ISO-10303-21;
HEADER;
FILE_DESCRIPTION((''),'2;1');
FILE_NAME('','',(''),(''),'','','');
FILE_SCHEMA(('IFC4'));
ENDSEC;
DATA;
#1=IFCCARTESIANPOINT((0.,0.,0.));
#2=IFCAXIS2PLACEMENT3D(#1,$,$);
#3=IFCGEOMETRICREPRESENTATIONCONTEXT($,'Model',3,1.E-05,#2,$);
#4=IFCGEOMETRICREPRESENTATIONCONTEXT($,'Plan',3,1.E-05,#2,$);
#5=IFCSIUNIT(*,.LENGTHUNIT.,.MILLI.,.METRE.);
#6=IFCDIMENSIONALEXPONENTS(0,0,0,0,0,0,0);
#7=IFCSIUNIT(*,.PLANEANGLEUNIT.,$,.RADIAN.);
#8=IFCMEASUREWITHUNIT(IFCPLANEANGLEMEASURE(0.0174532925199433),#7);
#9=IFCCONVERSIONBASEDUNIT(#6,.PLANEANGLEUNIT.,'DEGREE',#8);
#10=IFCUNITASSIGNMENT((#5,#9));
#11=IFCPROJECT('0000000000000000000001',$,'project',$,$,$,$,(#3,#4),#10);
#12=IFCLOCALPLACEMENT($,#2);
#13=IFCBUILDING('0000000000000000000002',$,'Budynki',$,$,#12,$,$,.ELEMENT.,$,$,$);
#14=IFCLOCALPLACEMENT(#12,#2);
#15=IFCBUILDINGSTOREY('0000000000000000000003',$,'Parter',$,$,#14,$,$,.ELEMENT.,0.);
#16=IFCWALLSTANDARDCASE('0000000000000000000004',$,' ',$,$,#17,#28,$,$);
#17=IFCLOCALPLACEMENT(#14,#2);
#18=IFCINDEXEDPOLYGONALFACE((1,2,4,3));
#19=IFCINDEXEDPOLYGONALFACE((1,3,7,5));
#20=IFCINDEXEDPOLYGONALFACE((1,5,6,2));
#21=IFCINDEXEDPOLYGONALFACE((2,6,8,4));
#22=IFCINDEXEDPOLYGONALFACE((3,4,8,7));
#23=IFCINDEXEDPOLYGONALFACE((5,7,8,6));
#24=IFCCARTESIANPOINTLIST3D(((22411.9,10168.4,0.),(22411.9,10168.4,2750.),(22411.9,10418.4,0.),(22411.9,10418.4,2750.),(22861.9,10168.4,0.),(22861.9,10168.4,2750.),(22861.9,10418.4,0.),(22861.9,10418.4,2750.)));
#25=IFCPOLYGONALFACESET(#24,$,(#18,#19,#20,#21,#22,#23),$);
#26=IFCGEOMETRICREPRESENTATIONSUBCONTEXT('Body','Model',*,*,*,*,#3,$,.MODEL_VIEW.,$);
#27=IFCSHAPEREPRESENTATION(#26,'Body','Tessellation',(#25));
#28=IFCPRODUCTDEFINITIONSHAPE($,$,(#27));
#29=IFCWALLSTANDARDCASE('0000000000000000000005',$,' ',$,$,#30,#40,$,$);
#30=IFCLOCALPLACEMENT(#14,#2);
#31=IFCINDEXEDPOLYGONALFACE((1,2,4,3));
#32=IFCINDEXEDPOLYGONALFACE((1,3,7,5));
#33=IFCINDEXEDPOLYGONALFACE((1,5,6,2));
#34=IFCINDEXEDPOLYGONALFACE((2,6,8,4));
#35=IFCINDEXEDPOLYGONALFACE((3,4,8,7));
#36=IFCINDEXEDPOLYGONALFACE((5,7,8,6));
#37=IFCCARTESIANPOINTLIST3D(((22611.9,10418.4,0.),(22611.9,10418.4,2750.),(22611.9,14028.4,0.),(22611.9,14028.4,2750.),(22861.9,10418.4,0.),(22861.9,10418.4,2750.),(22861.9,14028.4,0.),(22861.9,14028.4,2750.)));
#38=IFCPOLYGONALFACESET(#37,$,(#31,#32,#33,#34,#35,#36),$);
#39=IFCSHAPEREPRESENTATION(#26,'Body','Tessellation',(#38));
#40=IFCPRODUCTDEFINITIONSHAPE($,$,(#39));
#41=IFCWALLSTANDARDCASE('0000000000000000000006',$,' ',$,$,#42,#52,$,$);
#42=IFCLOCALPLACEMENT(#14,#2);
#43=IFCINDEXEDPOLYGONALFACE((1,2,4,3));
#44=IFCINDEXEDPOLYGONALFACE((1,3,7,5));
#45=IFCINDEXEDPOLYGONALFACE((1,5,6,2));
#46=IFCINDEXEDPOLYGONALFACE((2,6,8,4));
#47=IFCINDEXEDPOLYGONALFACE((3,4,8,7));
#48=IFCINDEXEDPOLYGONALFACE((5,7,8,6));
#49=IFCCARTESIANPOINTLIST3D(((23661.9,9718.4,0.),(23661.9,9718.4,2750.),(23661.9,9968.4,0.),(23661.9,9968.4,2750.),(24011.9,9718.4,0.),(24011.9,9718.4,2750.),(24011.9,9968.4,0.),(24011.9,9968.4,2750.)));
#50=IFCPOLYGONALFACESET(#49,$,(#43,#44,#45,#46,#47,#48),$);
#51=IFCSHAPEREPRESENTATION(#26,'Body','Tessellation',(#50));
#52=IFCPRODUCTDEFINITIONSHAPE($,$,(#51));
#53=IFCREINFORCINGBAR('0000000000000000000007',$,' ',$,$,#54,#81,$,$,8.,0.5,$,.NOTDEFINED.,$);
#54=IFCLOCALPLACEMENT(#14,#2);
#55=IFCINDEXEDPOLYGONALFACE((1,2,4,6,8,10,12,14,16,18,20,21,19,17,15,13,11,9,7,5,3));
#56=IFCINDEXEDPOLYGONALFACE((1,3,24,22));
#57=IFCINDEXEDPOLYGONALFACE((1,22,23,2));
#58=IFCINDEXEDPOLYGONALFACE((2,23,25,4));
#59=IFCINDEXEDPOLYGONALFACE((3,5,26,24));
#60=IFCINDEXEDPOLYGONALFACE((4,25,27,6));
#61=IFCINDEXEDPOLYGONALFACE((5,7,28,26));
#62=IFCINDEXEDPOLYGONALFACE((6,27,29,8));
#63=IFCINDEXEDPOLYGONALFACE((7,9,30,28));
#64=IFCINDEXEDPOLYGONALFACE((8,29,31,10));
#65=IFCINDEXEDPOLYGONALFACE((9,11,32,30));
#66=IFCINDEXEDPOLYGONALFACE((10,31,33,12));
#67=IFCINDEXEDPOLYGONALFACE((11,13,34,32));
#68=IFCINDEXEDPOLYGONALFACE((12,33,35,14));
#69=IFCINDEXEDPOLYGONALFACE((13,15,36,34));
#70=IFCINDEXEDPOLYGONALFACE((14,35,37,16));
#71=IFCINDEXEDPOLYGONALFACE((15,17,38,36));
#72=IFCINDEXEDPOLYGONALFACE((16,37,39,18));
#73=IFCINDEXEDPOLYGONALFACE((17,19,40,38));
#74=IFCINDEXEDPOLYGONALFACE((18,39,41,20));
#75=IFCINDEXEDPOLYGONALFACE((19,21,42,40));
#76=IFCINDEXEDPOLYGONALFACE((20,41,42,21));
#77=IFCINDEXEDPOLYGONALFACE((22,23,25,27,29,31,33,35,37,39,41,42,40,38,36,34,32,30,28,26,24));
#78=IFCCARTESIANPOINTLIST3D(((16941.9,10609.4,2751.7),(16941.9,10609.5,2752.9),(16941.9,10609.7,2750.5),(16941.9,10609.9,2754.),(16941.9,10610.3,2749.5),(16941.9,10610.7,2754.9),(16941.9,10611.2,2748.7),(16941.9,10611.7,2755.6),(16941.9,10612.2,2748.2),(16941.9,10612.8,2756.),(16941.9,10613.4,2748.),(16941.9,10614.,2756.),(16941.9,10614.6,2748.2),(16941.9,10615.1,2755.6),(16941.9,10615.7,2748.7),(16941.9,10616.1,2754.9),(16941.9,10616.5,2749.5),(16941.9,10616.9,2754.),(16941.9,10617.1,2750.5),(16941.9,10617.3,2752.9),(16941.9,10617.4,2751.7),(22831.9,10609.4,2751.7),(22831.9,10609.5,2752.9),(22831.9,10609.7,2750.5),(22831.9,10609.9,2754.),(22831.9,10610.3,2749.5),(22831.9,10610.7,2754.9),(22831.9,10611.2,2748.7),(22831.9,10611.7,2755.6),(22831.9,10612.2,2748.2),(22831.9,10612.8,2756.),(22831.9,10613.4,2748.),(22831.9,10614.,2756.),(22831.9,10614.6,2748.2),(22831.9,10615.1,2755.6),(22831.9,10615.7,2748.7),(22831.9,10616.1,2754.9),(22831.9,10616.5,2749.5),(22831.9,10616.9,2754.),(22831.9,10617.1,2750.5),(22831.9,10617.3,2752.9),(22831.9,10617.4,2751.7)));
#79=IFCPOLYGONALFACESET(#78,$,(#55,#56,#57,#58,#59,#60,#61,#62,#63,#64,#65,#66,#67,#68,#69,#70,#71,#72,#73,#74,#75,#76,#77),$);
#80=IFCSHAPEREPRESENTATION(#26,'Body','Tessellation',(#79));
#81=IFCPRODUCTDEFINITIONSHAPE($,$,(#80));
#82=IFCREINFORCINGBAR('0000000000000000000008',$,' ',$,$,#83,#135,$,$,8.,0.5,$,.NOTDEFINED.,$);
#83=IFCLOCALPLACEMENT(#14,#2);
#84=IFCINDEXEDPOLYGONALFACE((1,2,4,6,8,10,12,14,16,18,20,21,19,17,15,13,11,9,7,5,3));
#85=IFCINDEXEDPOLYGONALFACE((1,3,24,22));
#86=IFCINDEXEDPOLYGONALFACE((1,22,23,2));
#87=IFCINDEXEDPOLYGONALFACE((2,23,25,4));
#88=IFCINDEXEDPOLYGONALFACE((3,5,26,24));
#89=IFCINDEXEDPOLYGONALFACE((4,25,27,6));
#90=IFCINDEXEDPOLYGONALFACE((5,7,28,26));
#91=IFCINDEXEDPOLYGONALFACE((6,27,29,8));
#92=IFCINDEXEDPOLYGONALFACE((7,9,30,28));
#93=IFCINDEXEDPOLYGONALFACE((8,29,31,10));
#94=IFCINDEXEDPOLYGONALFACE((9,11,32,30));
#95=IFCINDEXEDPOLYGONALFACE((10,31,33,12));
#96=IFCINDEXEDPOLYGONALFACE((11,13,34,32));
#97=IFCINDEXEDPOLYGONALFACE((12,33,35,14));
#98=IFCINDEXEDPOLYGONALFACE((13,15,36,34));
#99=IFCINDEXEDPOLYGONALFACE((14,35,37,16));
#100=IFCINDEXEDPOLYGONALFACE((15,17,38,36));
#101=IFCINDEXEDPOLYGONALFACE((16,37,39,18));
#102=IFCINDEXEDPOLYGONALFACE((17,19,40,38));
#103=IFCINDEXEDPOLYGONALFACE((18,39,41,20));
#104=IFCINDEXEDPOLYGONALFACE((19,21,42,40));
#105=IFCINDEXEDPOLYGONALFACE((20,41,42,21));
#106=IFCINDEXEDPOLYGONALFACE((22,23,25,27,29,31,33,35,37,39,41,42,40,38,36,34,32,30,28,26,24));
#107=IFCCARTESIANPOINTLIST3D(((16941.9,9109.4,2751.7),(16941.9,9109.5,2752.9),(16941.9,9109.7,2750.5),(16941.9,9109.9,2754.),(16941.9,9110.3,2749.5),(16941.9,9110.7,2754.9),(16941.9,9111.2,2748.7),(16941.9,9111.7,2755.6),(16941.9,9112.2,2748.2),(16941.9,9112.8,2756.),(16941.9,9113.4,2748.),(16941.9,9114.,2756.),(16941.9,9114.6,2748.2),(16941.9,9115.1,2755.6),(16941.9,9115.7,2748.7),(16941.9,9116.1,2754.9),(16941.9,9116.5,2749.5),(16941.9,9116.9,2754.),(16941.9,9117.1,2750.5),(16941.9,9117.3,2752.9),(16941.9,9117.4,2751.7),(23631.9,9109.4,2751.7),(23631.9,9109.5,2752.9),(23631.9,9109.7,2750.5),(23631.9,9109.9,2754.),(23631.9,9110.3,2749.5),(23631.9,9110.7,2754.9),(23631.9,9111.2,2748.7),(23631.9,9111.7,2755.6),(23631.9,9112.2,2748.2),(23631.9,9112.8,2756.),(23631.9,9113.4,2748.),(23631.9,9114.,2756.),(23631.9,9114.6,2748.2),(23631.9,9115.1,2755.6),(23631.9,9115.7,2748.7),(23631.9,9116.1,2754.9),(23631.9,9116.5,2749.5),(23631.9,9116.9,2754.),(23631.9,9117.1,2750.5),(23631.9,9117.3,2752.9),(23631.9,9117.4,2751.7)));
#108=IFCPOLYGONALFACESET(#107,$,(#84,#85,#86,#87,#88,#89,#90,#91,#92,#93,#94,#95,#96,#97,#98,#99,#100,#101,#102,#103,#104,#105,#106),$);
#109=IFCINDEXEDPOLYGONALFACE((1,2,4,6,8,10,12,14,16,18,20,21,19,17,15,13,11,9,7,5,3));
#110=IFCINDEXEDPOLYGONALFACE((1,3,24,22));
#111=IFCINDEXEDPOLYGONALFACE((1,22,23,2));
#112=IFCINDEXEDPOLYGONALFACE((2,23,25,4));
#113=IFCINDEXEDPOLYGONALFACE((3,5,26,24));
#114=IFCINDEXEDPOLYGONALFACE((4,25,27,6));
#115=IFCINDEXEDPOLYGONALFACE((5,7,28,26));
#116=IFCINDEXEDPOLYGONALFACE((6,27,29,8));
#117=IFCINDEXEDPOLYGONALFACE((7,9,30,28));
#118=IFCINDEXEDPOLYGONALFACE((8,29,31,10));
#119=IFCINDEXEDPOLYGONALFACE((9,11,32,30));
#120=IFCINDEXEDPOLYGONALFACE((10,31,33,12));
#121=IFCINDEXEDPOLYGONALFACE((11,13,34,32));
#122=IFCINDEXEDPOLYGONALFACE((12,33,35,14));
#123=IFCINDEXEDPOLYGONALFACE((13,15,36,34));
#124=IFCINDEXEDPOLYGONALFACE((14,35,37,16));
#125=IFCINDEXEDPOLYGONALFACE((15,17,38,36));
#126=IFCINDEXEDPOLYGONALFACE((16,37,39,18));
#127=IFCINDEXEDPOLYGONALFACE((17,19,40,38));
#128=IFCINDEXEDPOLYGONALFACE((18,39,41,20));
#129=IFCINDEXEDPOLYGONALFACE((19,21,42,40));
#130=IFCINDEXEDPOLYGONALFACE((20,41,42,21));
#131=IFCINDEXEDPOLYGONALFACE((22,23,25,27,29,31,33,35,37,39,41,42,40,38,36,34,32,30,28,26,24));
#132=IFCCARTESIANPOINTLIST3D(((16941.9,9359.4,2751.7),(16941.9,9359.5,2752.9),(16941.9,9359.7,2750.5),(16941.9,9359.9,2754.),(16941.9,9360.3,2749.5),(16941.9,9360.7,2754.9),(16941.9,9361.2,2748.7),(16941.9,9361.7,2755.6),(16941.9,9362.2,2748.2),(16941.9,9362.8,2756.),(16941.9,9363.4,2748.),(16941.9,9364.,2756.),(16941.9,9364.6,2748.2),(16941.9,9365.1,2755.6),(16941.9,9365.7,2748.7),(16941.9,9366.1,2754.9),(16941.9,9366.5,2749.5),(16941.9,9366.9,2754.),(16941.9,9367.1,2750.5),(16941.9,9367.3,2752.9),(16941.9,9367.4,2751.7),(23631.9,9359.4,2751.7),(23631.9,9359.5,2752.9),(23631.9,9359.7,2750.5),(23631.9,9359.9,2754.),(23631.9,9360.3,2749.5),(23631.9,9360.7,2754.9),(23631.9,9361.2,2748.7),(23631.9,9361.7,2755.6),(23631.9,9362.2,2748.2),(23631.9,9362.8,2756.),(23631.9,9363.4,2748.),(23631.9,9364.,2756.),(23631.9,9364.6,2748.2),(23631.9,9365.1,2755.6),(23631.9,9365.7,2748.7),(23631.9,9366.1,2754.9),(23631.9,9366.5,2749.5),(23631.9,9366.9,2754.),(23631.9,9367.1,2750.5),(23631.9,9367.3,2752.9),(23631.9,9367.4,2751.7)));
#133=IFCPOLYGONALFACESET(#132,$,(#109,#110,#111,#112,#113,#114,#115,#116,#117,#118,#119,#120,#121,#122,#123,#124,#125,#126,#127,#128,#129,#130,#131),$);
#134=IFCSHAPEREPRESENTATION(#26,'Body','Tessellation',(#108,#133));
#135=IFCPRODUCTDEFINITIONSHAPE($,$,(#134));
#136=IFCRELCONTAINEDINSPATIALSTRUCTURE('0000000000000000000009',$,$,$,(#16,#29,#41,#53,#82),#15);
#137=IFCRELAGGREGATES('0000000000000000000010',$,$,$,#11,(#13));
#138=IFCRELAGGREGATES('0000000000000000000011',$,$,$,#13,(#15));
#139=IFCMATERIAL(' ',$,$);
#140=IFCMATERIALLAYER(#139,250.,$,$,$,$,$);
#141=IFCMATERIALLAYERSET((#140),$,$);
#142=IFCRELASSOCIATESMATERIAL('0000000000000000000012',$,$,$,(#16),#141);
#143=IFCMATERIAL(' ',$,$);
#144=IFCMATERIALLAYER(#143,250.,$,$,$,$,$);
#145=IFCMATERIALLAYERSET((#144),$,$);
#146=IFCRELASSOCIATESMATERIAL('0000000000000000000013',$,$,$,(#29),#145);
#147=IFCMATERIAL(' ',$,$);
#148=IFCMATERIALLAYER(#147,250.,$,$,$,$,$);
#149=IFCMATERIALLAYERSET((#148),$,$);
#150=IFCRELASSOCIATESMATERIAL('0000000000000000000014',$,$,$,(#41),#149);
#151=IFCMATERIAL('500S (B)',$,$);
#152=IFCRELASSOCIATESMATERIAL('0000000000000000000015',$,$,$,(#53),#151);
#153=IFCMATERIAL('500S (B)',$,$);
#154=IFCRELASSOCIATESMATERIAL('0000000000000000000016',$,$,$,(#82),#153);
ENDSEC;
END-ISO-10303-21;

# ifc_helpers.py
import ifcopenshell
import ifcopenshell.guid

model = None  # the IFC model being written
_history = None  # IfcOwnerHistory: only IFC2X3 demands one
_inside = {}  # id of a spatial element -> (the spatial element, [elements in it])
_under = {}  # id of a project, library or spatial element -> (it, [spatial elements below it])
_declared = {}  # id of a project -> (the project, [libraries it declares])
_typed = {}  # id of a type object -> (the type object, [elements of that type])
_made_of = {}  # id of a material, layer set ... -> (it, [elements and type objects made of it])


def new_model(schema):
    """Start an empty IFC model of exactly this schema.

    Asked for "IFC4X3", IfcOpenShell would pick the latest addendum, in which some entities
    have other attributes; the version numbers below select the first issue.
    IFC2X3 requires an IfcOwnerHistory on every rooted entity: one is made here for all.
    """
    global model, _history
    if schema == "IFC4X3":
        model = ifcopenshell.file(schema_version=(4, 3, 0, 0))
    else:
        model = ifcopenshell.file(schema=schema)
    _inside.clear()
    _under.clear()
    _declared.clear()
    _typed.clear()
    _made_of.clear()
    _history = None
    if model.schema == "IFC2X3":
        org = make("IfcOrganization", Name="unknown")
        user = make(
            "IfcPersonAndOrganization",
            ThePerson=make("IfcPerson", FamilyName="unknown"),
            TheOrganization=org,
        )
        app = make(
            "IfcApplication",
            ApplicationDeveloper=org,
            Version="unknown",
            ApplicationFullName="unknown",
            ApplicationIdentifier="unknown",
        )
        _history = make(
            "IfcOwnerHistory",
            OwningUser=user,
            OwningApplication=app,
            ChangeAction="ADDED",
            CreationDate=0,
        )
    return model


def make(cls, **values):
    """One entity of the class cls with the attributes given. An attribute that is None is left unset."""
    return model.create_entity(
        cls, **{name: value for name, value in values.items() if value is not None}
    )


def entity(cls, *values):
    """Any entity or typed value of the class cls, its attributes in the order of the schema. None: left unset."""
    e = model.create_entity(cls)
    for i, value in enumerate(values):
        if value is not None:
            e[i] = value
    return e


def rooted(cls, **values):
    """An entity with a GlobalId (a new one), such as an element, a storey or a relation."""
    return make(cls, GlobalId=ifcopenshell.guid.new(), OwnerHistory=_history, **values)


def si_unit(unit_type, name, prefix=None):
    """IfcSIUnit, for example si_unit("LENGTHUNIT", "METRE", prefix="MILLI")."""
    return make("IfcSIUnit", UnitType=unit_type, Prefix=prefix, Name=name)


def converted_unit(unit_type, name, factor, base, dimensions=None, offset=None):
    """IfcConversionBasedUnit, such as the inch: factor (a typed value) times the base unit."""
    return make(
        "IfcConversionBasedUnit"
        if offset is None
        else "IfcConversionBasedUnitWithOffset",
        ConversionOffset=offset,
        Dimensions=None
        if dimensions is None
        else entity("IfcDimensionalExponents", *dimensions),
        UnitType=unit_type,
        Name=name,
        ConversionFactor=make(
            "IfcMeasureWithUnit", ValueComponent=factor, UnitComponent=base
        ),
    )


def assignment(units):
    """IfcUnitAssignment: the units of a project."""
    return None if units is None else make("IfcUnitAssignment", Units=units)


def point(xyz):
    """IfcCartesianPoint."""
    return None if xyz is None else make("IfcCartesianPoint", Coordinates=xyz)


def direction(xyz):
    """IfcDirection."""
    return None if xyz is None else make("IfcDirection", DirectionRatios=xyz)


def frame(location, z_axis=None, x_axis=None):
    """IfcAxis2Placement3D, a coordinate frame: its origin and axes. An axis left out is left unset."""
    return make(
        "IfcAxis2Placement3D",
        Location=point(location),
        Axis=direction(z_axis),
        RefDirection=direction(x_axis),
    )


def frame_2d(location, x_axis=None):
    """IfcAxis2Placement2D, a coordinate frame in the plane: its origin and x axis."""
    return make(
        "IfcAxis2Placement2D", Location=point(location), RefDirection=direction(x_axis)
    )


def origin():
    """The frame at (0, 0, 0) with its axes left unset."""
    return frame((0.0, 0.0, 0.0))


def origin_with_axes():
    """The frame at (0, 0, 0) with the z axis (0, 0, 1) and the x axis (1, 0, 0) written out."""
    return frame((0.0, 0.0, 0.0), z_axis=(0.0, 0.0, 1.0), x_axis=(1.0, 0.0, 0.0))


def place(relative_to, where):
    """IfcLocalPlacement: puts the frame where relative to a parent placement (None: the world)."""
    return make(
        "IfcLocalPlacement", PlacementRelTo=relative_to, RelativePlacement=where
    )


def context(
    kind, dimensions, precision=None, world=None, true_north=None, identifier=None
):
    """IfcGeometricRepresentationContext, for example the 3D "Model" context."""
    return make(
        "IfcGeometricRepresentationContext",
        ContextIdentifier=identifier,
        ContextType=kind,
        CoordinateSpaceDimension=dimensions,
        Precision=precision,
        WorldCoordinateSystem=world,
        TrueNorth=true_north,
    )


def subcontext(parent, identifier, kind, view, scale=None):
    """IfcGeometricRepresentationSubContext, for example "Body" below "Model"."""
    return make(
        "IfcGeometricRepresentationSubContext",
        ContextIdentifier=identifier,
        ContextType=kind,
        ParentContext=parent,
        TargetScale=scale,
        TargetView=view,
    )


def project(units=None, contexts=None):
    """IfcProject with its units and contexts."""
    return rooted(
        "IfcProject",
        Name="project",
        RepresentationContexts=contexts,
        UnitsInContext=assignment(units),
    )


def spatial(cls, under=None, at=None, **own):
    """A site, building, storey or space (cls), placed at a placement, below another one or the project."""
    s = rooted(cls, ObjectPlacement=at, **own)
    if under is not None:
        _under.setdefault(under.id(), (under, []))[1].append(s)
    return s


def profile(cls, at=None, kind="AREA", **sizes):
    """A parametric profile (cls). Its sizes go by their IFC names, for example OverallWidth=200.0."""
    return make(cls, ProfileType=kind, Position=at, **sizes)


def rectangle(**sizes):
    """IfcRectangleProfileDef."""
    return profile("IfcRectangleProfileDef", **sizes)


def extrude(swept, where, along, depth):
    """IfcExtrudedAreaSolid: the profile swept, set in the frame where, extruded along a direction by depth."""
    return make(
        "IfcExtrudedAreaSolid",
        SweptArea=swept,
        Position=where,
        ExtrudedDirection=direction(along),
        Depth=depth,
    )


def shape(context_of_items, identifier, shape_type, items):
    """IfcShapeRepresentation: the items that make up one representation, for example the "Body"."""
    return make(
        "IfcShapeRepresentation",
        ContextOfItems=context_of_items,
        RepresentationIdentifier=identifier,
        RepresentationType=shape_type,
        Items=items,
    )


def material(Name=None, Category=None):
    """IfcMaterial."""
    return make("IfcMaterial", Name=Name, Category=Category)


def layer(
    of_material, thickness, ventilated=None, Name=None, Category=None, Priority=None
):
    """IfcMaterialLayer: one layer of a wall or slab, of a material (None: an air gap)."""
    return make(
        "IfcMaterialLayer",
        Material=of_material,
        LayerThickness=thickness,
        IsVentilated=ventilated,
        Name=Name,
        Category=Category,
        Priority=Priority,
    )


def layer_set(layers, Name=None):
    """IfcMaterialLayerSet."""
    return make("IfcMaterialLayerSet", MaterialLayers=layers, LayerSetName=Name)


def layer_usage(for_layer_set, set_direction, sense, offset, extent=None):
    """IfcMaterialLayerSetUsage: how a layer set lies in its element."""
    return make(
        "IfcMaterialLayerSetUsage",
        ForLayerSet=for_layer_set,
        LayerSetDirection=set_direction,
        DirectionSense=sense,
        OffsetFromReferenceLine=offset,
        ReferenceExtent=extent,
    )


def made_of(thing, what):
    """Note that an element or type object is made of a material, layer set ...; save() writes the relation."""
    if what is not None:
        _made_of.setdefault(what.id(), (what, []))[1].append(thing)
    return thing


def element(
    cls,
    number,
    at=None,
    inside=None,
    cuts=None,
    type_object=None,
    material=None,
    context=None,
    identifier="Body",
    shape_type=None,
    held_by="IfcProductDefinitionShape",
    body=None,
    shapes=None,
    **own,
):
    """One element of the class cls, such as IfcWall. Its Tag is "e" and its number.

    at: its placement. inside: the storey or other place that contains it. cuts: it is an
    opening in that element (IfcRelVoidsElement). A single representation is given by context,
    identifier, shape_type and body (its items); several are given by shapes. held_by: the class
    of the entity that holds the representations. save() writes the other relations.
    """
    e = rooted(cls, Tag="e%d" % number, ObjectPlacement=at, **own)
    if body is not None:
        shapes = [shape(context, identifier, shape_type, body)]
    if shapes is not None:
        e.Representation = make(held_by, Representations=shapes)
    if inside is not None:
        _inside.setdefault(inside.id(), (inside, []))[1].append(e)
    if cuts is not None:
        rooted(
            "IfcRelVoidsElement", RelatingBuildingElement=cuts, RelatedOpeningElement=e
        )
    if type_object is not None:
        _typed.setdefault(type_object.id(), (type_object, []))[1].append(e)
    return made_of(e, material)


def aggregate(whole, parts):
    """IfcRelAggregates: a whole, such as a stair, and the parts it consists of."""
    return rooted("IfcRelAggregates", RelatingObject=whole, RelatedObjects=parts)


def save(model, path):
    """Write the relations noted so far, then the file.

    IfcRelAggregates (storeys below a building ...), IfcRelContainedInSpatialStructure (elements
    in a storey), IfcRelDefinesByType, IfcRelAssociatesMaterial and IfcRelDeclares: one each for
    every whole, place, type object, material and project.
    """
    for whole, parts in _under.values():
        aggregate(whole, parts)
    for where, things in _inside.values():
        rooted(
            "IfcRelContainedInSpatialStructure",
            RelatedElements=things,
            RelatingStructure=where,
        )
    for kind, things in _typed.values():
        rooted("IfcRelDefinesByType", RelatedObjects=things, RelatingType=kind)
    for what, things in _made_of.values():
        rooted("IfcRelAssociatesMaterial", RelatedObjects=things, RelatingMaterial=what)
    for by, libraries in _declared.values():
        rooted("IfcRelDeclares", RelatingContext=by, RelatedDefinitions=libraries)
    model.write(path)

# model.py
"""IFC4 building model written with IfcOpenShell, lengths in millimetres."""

from ifc_helpers import new_model, entity, si_unit, converted_unit, frame, frame_2d, origin, origin_with_axes, place, context, subcontext, project, spatial, rectangle, extrude, material, layer, layer_set, layer_usage, element, save


model = new_model("IFC4")

# Units and contexts
model_context = context("Model", 3, precision=1e-05, world=origin())
plan_context = context("Plan", 3, precision=1e-05, world=origin())
body_context = subcontext(model_context, "Body", "Model", "MODEL_VIEW")
ifc_project = project(units=[si_unit("LENGTHUNIT", "METRE", prefix="MILLI"), converted_unit("PLANEANGLEUNIT", "DEGREE", entity("IfcPlaneAngleMeasure", 0.0174532925199433), si_unit("PLANEANGLEUNIT", "RADIAN"), dimensions=[0, 0, 0, 0, 0, 0, 0])], contexts=[model_context, plan_context])

# Building, storey
building_placement = place(None, origin())
building = spatial("IfcBuilding", under=ifc_project, at=building_placement, Name="Budynki", CompositionType="ELEMENT")
storey_placement = place(building_placement, origin())
storey = spatial("IfcBuildingStorey", under=building, at=storey_placement, Name="Parter", CompositionType="ELEMENT", Elevation=0.0)

# Walls
ifc_material_1 = material(Name=" ")
ifc_layer_1 = layer(ifc_material_1, 250.0)
ifc_layer_set_1 = layer_set([ifc_layer_1])
ifc_layer_usage_1 = layer_usage(ifc_layer_set_1, "AXIS2", "POSITIVE", 0.0)
wall_1_placement = place(storey_placement, frame((22411.9, 10168.4, 0.0)))
element("IfcWallStandardCase", 1, at=wall_1_placement, inside=storey, material=ifc_layer_usage_1, Name=" ", context=body_context, shape_type="SweptSolid", body=[
    extrude(rectangle(XDim=450.0, YDim=250.0, at=frame_2d((225.0, 125.0), x_axis=(1.0, 0.0))), origin_with_axes(), (0.0, 0.0, 1.0), 2750.0),
])
ifc_material_2 = material(Name=" ")
ifc_layer_2 = layer(ifc_material_2, 250.0)
ifc_layer_set_2 = layer_set([ifc_layer_2])
ifc_layer_usage_2 = layer_usage(ifc_layer_set_2, "AXIS2", "POSITIVE", 0.0)
wall_2_placement = place(storey_placement, frame((22861.9, 10418.4, 0.0), z_axis=(0.0, 0.0, 1.0), x_axis=(0.0, 1.0, 0.0)))
element("IfcWallStandardCase", 2, at=wall_2_placement, inside=storey, material=ifc_layer_usage_2, Name=" ", context=body_context, shape_type="SweptSolid", body=[
    extrude(rectangle(XDim=3610.0, YDim=250.0, at=frame_2d((1805.0, 125.0), x_axis=(1.0, 0.0))), origin_with_axes(), (0.0, 0.0, 1.0), 2750.0),
])
ifc_material_3 = material(Name=" ")
ifc_layer_3 = layer(ifc_material_3, 250.0)
ifc_layer_set_3 = layer_set([ifc_layer_3])
ifc_layer_usage_3 = layer_usage(ifc_layer_set_3, "AXIS2", "POSITIVE", 0.0)
wall_3_placement = place(storey_placement, frame((24011.9, 9968.4, 0.0), z_axis=(0.0, 0.0, 1.0), x_axis=(-1.0, 0.0, 0.0)))
element("IfcWallStandardCase", 3, at=wall_3_placement, inside=storey, material=ifc_layer_usage_3, Name=" ", context=body_context, shape_type="SweptSolid", body=[
    extrude(rectangle(XDim=350.0, YDim=250.0, at=frame_2d((175.0, 125.0), x_axis=(1.0, 0.0))), origin_with_axes(), (0.0, 0.0, 1.0), 2750.0),
])

# Reinforcing bars
ifc_material_4 = material(Name="500S (B)")
reinforcing_bar_1_placement = place(storey_placement, frame((22831.9, 10613.4, 2752.0)))
element("IfcReinforcingBar", 4, at=reinforcing_bar_1_placement, inside=storey, material=ifc_material_4, Name=" ", CrossSectionArea=0.5, NominalDiameter=8.0, PredefinedType="NOTDEFINED", context=body_context, shape_type="AdvancedSweptSolid", body=[
    entity("IfcSweptDiskSolid", entity("IfcPolyline", [entity("IfcCartesianPoint", [0.0, 0.0, 0.0]), entity("IfcCartesianPoint", [-5890.0, 0.0, 0.0])]), 4.0, None, 0.0, 1.0),
])
ifc_material_5 = material(Name="500S (B)")
reinforcing_bar_2_placement = place(storey_placement, frame((23631.9, 9113.4, 2752.0)))
element("IfcReinforcingBar", 5, at=reinforcing_bar_2_placement, inside=storey, material=ifc_material_5, Name=" ", CrossSectionArea=0.5, NominalDiameter=8.0, PredefinedType="NOTDEFINED", context=body_context, shape_type="AdvancedSweptSolid", body=[
    entity("IfcSweptDiskSolid", entity("IfcPolyline", [entity("IfcCartesianPoint", [0.0, 0.0, 0.0]), entity("IfcCartesianPoint", [-6690.0, 0.0, 0.0])]), 4.0, None, 0.0, 1.0),
    entity("IfcSweptDiskSolid", entity("IfcPolyline", [entity("IfcCartesianPoint", [0.0, 250.0, 0.0]), entity("IfcCartesianPoint", [-6690.0, 250.0, 0.0])]), 4.0, None, 0.0, 1.0),
])

save(model, "model.ifc")
